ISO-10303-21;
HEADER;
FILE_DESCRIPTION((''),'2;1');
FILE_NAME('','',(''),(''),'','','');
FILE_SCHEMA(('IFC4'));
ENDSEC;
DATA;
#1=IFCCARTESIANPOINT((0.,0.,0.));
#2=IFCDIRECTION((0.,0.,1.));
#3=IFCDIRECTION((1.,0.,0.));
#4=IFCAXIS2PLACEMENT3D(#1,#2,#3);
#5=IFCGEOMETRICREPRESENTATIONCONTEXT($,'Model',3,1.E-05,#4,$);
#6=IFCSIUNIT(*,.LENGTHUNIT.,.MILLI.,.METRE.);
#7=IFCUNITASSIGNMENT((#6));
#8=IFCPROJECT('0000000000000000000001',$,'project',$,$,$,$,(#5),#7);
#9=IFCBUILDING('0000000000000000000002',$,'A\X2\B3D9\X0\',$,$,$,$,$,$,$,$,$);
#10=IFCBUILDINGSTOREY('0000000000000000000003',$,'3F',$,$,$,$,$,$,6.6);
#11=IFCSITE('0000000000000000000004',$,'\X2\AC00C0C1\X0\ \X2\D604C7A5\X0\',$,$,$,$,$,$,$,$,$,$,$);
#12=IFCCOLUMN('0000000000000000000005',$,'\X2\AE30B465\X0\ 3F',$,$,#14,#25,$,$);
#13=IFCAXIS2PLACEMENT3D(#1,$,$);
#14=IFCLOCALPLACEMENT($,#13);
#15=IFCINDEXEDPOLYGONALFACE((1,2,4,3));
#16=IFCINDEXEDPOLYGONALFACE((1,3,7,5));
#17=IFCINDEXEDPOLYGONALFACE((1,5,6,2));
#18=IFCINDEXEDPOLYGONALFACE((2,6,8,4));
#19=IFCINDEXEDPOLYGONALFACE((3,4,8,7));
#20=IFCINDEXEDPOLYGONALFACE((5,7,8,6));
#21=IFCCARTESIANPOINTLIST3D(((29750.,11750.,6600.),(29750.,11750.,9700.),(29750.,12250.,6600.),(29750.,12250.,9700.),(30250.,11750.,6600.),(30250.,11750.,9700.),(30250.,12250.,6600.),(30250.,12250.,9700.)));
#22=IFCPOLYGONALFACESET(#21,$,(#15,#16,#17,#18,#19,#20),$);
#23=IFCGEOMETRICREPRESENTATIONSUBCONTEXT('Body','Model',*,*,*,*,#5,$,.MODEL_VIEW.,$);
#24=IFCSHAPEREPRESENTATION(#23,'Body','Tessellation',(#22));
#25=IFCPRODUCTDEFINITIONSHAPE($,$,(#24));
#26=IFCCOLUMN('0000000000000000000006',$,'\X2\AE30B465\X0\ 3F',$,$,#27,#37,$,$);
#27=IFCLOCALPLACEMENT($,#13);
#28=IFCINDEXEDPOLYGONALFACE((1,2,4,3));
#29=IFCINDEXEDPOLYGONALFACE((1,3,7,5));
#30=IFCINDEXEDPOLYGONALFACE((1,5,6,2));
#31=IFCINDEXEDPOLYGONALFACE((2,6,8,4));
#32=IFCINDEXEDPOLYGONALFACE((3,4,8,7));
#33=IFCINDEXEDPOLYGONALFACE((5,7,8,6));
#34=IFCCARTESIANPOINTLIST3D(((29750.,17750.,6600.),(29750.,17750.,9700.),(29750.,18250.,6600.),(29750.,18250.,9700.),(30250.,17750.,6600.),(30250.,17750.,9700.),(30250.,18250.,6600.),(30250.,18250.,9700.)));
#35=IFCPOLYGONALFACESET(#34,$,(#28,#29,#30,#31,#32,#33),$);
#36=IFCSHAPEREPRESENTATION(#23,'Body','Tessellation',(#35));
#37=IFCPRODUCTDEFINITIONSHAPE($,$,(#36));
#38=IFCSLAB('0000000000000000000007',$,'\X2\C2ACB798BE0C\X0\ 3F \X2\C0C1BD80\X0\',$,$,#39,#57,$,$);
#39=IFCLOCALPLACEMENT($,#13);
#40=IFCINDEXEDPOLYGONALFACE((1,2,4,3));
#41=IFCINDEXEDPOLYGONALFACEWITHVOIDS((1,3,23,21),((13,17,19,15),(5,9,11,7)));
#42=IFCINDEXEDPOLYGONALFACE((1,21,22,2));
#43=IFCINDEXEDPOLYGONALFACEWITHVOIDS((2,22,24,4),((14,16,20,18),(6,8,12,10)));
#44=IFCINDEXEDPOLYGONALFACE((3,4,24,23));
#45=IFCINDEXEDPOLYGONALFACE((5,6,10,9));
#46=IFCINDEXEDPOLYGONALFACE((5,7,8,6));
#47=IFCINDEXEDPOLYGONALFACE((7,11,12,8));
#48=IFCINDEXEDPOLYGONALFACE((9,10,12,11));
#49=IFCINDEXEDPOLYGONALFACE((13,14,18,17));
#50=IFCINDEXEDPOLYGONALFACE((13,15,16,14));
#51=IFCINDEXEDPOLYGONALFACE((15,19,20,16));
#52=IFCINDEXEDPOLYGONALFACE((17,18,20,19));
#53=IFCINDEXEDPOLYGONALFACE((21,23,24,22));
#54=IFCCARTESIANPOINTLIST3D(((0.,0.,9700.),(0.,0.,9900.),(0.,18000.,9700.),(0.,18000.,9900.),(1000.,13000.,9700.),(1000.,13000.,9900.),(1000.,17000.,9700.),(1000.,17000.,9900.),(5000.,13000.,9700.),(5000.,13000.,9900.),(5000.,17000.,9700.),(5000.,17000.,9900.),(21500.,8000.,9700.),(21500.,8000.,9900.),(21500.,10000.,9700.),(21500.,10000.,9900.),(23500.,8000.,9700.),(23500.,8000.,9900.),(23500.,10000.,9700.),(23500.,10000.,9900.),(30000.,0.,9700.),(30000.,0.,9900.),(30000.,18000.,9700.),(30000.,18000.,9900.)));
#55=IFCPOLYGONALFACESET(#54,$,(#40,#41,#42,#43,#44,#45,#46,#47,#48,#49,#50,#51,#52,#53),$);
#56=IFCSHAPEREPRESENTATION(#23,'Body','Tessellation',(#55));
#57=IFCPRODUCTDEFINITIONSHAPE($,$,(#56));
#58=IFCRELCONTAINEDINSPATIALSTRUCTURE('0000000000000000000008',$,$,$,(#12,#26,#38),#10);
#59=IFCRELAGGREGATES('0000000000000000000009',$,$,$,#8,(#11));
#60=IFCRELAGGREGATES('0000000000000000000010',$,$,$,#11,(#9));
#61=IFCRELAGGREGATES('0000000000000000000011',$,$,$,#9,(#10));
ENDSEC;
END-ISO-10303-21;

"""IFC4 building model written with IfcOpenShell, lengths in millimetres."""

from ifc_helpers import new_model, si_unit, frame, origin_with_axes, place, context, subcontext, project, spatial, indexed_curve, outline, extrude, element, save


model = new_model("IFC4")

# Units and contexts
model_context = context("Model", 3, precision=1e-05, world=origin_with_axes())
body_context = subcontext(model_context, "Body", "Model", "MODEL_VIEW")
ifc_project = project(units=[si_unit("LENGTHUNIT", "METRE", prefix="MILLI")], contexts=[model_context])

# Site, building, storey
site = spatial("IfcSite", under=ifc_project, Name="가상 현장")
building = spatial("IfcBuilding", under=site, Name="A동")
storey = spatial("IfcBuildingStorey", under=building, Name="3F", Elevation=6.6)

# Columns
for number, where, z_axis, x_axis, name in (
    (1, (29750.0, 11750.0, 6600.0), (0.0, 0.0, 1.0), (1.0, 0.0, 0.0), "기둥 3F"),
    (2, (29750.0, 17750.0, 6600.0), (0.0, 0.0, 1.0), (1.0, 0.0, 0.0), "기둥 3F"),
):
    element("IfcColumn", number, at=place(None, frame(where, z_axis=z_axis, x_axis=x_axis)), inside=storey, Name=name, context=body_context, shape_type="SweptSolid", body=[
        extrude(outline(indexed_curve([(0.0, 0.0), (0.0, 500.0), (500.0, 500.0), (500.0, 0.0), (0.0, 0.0)], self_intersect=False)), origin_with_axes(), (0.0, 0.0, 1.0), 3100.0),
    ])

# Slab, openings
slab_placement = place(None, frame((0.0, 0.0, 9700.0), z_axis=(0.0, 0.0, 1.0), x_axis=(1.0, 0.0, 0.0)))
slab = element("IfcSlab", 3, at=slab_placement, inside=storey, Name="슬래브 3F 상부", context=body_context, shape_type="SweptSolid", body=[
    extrude(outline(indexed_curve([(0.0, 0.0), (30000.0, 0.0), (30000.0, 18000.0), (0.0, 18000.0)])), None, (0.0, 0.0, 1.0), 200.0),
])
opening_1_placement = place(slab_placement, frame((1000.0, 13000.0, -10.0), z_axis=(0.0, 0.0, 1.0), x_axis=(1.0, 0.0, 0.0)))
element("IfcOpeningElement", 4, at=opening_1_placement, cuts=slab, context=body_context, shape_type="SweptSolid", body=[
    extrude(outline(indexed_curve([(0.0, 0.0), (4000.0, 0.0), (4000.0, 4000.0), (0.0, 4000.0)])), None, (0.0, 0.0, 1.0), 220.0),
])
opening_2_placement = place(slab_placement, frame((21500.0, 8000.0, -10.0), z_axis=(0.0, 0.0, 1.0), x_axis=(1.0, 0.0, 0.0)))
element("IfcOpeningElement", 5, at=opening_2_placement, cuts=slab, context=body_context, shape_type="SweptSolid", body=[
    extrude(outline(indexed_curve([(0.0, 0.0), (2000.0, 0.0), (2000.0, 2000.0), (0.0, 2000.0)])), None, (0.0, 0.0, 1.0), 220.0),
])

save(model, "model.ifc")
